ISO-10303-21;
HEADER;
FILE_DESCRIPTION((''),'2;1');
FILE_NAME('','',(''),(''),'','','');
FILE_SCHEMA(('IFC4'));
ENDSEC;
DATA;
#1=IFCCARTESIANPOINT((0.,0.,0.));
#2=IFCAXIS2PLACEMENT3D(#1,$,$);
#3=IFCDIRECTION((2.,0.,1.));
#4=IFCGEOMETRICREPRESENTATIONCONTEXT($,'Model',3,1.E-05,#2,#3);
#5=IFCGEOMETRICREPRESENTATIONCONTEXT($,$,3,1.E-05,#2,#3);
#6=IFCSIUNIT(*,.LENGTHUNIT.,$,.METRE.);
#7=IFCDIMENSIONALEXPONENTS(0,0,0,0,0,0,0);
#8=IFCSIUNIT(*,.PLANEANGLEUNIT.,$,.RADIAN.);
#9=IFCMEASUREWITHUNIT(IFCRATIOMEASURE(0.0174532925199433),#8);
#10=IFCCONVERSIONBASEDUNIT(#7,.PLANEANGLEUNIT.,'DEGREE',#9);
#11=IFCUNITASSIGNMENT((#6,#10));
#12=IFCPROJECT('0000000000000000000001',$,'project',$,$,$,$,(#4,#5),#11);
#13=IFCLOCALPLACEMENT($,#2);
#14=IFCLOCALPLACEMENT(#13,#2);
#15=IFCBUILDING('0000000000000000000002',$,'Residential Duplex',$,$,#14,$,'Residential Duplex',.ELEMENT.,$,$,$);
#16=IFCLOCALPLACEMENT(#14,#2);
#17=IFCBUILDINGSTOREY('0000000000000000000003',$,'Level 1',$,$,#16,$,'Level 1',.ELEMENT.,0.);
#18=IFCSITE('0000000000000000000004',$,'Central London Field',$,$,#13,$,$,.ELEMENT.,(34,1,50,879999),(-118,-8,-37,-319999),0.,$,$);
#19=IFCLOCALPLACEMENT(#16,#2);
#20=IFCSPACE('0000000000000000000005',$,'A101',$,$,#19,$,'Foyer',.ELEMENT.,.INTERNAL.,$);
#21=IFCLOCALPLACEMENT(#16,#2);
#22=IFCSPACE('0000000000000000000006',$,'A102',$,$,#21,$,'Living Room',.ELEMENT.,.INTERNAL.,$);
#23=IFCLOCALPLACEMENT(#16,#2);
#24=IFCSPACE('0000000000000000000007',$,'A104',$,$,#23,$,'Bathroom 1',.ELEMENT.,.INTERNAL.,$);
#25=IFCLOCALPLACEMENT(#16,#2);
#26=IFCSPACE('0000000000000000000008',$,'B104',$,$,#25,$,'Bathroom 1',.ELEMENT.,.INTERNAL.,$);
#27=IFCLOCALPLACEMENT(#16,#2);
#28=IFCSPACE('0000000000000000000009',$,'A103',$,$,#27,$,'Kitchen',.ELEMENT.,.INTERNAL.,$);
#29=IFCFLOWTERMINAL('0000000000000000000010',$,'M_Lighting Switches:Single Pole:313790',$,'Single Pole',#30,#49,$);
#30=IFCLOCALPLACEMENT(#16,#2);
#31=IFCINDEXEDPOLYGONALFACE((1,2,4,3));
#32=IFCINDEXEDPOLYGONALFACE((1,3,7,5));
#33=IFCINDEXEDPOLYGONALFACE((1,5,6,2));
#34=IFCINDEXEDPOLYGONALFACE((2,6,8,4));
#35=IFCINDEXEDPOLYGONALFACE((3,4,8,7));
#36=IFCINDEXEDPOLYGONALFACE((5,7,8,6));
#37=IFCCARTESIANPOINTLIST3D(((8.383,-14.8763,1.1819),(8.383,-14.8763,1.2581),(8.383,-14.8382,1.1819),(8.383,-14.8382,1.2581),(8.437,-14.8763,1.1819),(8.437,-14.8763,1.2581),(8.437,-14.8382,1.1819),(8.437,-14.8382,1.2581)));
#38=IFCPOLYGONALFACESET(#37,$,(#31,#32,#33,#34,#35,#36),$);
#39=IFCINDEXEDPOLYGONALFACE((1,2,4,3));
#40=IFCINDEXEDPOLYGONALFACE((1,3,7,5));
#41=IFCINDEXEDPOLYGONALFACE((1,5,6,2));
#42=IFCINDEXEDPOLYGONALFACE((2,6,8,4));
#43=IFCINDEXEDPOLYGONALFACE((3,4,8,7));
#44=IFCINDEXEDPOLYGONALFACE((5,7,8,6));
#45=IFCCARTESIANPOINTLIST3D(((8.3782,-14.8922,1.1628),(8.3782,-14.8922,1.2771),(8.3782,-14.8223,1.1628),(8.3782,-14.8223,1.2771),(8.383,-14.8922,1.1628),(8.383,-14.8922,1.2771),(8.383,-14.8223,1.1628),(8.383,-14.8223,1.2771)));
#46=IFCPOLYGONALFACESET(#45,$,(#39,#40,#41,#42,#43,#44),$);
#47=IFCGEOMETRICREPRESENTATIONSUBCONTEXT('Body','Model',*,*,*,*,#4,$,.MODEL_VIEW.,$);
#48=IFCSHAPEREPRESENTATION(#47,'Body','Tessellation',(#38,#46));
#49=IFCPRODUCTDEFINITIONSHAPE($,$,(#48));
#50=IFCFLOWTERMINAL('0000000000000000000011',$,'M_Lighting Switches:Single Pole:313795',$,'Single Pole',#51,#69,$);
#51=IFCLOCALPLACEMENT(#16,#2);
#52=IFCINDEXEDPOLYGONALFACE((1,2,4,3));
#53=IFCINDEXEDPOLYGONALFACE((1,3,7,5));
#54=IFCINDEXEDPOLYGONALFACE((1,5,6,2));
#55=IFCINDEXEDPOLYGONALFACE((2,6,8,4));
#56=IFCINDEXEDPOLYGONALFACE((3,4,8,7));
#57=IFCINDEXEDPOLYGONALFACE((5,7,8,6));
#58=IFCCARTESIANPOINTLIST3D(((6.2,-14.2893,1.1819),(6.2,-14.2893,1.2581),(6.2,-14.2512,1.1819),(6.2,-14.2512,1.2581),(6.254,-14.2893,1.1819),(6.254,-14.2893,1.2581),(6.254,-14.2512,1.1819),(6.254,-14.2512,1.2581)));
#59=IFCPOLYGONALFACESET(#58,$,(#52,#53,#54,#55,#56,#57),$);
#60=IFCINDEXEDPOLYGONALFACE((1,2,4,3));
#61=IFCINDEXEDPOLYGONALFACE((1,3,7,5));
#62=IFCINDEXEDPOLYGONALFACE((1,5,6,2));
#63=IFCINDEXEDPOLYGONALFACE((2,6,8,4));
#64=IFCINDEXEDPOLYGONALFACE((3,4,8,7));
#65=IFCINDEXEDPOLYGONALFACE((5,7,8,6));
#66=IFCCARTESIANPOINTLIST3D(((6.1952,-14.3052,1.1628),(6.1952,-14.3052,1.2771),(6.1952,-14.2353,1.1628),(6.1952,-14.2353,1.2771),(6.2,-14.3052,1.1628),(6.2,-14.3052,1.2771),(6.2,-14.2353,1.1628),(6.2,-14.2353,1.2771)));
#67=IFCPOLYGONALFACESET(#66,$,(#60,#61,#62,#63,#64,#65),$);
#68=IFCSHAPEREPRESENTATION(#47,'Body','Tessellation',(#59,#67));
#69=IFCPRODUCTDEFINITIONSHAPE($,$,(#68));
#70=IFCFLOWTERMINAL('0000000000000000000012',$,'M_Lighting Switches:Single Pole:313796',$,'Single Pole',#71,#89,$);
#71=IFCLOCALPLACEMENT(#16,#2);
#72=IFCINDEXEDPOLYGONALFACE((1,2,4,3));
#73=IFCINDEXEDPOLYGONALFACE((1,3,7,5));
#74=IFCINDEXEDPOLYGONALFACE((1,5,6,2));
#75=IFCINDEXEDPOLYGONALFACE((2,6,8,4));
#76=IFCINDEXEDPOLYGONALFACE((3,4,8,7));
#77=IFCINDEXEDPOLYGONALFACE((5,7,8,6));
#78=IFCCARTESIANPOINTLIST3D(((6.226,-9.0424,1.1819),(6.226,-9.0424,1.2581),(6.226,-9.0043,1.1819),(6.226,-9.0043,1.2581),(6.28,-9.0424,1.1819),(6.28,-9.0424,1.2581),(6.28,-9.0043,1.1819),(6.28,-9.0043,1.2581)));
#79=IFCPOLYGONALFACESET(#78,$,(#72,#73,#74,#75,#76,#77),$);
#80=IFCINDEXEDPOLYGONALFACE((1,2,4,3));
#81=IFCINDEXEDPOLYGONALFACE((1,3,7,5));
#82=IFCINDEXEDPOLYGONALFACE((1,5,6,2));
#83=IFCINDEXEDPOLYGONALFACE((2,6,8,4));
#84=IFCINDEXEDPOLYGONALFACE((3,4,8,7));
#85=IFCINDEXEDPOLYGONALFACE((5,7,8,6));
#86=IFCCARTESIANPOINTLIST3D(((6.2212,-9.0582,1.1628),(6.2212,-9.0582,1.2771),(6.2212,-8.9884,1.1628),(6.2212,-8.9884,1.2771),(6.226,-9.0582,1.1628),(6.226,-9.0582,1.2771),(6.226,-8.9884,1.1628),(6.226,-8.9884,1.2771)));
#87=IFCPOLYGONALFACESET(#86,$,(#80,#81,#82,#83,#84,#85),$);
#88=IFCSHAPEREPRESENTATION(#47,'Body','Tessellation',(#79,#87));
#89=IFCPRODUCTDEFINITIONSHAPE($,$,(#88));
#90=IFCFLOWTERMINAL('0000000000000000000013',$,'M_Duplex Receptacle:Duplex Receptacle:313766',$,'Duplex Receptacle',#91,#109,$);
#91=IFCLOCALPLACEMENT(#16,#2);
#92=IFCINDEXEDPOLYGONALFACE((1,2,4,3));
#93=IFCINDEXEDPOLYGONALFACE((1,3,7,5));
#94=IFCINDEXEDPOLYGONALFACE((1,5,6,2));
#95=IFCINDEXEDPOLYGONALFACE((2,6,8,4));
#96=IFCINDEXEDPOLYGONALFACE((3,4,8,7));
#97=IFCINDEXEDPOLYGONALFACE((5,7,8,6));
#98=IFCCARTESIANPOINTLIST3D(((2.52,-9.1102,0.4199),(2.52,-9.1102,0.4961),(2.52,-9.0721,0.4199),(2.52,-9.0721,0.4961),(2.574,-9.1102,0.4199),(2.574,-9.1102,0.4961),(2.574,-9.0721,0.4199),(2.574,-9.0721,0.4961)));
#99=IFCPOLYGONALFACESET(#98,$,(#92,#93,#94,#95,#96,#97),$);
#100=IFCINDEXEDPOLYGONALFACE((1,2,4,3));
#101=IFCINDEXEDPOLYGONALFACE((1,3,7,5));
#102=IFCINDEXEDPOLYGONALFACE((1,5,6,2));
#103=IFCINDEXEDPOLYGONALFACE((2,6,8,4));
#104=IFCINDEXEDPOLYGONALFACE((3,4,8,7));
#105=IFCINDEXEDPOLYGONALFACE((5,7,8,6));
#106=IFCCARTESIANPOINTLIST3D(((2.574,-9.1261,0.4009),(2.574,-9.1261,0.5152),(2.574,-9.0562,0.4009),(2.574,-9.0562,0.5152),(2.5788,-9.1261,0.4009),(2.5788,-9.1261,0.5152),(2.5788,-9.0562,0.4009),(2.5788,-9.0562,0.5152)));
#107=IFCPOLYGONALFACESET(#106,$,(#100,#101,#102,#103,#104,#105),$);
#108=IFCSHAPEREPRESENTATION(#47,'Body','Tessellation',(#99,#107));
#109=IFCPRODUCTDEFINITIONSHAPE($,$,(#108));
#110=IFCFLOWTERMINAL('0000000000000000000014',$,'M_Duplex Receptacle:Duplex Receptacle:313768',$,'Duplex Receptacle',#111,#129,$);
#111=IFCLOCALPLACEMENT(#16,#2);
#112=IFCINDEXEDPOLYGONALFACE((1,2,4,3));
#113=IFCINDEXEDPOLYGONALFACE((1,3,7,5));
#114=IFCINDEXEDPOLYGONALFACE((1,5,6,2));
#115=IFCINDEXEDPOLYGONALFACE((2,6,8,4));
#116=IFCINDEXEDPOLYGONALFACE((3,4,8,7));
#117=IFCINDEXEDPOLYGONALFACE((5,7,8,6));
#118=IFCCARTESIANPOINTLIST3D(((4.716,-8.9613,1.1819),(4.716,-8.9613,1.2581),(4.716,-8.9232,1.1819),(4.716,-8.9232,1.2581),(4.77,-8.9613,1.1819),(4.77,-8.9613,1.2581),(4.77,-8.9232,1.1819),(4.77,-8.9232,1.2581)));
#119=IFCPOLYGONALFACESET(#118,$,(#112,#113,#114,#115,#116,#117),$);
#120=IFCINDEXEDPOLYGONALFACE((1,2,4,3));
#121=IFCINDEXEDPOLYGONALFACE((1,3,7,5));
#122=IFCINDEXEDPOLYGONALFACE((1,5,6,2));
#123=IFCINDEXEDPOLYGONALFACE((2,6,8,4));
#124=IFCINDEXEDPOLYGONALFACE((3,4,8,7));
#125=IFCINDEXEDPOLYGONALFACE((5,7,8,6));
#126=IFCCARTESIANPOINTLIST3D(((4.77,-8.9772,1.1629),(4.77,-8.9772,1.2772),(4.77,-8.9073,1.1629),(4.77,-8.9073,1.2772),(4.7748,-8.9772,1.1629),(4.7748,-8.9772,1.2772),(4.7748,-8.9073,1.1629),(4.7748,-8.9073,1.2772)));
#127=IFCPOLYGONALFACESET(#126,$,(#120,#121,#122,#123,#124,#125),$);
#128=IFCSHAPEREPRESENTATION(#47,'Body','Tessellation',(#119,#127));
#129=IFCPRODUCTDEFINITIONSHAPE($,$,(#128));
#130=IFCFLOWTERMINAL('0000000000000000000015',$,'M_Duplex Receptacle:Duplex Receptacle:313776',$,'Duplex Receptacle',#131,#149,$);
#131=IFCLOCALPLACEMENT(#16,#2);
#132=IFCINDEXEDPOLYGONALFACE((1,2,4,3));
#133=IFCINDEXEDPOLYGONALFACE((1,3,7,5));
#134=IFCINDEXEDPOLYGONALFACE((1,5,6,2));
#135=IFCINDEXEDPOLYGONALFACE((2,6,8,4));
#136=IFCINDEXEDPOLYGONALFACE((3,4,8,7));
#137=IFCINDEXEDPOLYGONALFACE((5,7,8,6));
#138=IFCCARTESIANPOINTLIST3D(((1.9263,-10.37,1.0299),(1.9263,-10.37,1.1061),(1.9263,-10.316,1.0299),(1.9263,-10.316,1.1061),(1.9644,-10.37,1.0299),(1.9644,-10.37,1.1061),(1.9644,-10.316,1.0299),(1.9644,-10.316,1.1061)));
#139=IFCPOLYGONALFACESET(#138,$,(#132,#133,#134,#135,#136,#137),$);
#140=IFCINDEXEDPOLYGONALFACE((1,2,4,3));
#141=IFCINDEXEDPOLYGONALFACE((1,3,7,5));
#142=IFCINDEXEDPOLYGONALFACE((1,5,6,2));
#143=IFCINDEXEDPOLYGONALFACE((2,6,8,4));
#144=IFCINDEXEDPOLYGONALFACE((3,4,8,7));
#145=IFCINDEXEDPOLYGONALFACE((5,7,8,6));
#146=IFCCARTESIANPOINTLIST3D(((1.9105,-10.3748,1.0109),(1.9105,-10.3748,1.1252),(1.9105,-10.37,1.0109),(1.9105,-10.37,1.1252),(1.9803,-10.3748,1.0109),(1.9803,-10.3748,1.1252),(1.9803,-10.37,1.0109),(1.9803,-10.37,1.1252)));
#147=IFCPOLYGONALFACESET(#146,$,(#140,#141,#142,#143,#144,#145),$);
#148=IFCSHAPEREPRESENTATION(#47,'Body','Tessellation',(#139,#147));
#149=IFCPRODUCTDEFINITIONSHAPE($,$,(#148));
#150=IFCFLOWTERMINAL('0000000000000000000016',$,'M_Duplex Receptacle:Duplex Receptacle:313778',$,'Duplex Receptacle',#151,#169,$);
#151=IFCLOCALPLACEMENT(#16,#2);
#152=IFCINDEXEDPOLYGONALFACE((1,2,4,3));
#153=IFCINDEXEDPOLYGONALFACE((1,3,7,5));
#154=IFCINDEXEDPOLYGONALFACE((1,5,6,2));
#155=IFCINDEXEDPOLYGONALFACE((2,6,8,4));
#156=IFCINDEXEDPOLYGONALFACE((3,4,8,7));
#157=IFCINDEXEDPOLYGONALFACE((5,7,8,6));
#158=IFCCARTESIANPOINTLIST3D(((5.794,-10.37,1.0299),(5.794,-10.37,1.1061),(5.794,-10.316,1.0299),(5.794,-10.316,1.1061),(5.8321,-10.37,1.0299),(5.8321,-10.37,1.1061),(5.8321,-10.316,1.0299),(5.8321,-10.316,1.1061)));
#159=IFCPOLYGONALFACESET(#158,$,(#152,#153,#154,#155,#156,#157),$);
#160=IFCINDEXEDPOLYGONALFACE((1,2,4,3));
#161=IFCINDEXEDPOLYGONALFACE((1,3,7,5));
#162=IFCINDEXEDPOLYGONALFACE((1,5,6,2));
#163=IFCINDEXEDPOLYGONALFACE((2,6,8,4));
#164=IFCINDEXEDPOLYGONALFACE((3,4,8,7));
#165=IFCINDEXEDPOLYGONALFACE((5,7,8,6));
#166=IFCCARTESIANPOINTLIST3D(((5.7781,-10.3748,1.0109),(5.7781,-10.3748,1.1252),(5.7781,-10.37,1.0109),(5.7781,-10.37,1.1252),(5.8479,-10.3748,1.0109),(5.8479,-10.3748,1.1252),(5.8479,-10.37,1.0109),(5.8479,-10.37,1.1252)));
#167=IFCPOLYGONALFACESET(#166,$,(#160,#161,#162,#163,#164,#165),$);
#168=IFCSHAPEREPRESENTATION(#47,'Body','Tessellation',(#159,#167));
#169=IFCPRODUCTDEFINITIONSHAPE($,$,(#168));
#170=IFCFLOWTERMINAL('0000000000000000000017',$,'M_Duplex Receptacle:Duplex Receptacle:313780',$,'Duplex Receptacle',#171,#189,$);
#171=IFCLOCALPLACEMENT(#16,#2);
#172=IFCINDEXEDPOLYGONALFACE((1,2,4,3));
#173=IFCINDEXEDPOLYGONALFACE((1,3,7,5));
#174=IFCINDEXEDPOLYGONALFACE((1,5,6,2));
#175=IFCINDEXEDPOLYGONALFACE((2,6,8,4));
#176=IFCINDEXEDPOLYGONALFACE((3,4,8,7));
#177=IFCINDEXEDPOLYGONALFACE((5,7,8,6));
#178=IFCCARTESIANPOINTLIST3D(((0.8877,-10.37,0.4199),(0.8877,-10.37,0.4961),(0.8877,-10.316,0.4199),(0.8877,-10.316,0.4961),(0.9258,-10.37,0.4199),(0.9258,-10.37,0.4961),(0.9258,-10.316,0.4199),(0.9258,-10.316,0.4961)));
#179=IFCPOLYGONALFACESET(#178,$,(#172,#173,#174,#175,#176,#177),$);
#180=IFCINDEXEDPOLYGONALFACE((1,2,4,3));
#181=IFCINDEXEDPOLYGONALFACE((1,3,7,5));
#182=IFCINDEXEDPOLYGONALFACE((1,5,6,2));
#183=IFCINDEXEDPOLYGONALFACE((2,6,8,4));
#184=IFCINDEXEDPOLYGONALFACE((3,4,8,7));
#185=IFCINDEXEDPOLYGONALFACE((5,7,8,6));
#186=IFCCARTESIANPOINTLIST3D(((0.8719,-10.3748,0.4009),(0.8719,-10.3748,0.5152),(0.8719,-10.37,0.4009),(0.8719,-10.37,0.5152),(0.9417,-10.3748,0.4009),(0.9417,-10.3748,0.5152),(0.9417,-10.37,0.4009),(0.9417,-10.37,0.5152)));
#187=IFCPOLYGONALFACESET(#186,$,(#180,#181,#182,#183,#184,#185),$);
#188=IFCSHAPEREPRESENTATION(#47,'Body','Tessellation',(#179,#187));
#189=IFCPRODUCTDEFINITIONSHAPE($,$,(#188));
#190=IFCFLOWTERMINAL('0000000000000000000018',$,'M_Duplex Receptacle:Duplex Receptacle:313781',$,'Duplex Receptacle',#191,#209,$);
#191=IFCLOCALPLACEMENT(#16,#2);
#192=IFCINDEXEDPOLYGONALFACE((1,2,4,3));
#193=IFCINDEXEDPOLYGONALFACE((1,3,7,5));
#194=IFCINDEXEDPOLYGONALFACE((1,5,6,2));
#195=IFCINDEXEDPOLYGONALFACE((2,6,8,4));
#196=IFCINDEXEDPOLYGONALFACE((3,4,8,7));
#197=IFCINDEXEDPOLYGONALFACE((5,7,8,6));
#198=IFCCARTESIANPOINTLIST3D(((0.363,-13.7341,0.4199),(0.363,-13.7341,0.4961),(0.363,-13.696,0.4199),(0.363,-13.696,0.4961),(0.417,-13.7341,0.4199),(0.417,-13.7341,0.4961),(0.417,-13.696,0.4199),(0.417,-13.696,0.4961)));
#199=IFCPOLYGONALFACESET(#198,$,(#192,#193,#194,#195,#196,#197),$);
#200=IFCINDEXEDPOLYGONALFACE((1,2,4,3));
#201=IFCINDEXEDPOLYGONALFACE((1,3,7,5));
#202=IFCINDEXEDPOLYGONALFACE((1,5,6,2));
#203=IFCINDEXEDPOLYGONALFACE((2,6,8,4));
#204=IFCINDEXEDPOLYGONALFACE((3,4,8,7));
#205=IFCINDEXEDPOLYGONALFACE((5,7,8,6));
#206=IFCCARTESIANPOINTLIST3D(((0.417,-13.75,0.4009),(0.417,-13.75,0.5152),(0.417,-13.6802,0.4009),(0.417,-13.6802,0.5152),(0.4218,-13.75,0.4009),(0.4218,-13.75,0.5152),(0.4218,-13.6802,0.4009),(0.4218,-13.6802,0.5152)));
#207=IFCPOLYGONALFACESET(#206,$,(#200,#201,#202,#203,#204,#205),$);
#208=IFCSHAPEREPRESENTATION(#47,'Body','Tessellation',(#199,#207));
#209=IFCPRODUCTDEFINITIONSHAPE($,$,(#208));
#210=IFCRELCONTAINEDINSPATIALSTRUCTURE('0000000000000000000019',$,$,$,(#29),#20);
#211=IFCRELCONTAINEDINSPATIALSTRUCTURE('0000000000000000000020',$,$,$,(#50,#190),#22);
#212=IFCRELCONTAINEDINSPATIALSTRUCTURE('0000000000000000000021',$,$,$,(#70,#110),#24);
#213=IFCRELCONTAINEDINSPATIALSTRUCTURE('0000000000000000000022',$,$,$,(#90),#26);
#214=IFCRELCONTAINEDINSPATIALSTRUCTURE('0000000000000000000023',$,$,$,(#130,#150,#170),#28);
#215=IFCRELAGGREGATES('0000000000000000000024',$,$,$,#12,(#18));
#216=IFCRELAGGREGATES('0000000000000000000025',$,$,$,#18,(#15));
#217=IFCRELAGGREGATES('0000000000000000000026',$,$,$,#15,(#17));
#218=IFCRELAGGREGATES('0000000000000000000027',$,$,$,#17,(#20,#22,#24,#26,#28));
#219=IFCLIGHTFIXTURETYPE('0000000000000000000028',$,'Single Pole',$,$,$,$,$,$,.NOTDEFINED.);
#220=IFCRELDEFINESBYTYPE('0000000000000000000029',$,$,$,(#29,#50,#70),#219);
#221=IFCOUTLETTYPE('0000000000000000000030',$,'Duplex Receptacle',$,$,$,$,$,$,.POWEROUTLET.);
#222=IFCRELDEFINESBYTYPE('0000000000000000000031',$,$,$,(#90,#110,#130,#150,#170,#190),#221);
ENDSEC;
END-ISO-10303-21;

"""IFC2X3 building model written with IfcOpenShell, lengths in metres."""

from ifc_helpers import new_model, entity, si_unit, converted_unit, direction, frame, frame_2d, origin, origin_2d_with_axis, place, context, subcontext, project, spatial, rectangle, extrude, source, transform, mapped, type_object, type_shapes, element, save


model = new_model("IFC2X3")

# Units and contexts
model_context = context("Model", 3, precision=1e-05, world=origin(), true_north=direction((2.0, 0.0, 1.0)))
context_of_model = context(None, 3, precision=1e-05, world=origin(), true_north=direction((2.0, 0.0, 1.0)))
body_context = subcontext(model_context, "Body", "Model", "MODEL_VIEW")
ifc_project = project(units=[si_unit("LENGTHUNIT", "METRE"), converted_unit("PLANEANGLEUNIT", "DEGREE", entity("IfcRatioMeasure", 0.0174532925199433), si_unit("PLANEANGLEUNIT", "RADIAN"), dimensions=[0, 0, 0, 0, 0, 0, 0])], contexts=[model_context, context_of_model])

# Site, building, storey, space
site_placement = place(None, origin())
site = spatial("IfcSite", under=ifc_project, at=site_placement, Name="Central London Field", CompositionType="ELEMENT", RefLatitude=(34, 1, 50, 879999), RefLongitude=(-118, -8, -37, -319999), RefElevation=0.0)
building_placement = place(site_placement, origin())
building = spatial("IfcBuilding", under=site, at=building_placement, Name="Residential Duplex", LongName="Residential Duplex", CompositionType="ELEMENT")
storey_placement = place(building_placement, origin())
storey = spatial("IfcBuildingStorey", under=building, at=storey_placement, Name="Level 1", LongName="Level 1", CompositionType="ELEMENT", Elevation=0.0)
space_1_placement = place(storey_placement, origin())
space_1 = spatial("IfcSpace", under=storey, at=space_1_placement, Name="A101", LongName="Foyer", CompositionType="ELEMENT", InteriorOrExteriorSpace="INTERNAL")

# Flow terminal
light_fixture_type = type_object("IfcLightFixtureType", Name="Single Pole", PredefinedType="NOTDEFINED")
shared_shape_1 = source(origin(), body_context, "Body", "SweptSolid", [
    extrude(rectangle(XDim=0.0381, YDim=0.0762, at=origin_2d_with_axis()), frame((0.0, 0.0, -0.054), z_axis=(0.0, 0.0, 1.0), x_axis=(-1.0, 0.0, 0.0)), (0.0, 0.0, 1.0), 0.054),
    extrude(rectangle(XDim=0.0698, YDim=0.1143, at=frame_2d((0.0, 0.0), x_axis=(1.0, 0.0))), frame((0.0, 0.0, 0.0), z_axis=(0.0, 0.0, 1.0), x_axis=(-1.0, 0.0, 0.0)), (0.0, 0.0, 1.0), 0.0048),
])
type_shapes(light_fixture_type, [shared_shape_1])
flow_terminal_1_placement = place(space_1_placement, frame((8.383, -14.8573, 1.22), z_axis=(-1.0, 0.0, 0.0), x_axis=(0.0, -1.0, 0.0)))
element("IfcFlowTerminal", 1, at=flow_terminal_1_placement, inside=space_1, type_object=light_fixture_type, Name="M_Lighting Switches:Single Pole:313790", ObjectType="Single Pole", context=body_context, shape_type="MappedRepresentation", body=[
    mapped(shared_shape_1, transform((0.0, 0.0, 0.0), scale=1.0)),
])

# Shared definitions
space_2_placement = place(storey_placement, origin())
space_2 = spatial("IfcSpace", under=storey, at=space_2_placement, Name="A102", LongName="Living Room", CompositionType="ELEMENT", InteriorOrExteriorSpace="INTERNAL")

# Flow terminal
flow_terminal_2_placement = place(space_2_placement, frame((6.2, -14.2702, 1.22), z_axis=(-1.0, 0.0, 0.0), x_axis=(0.0, -1.0, 0.0)))
element("IfcFlowTerminal", 2, at=flow_terminal_2_placement, inside=space_2, type_object=light_fixture_type, Name="M_Lighting Switches:Single Pole:313795", ObjectType="Single Pole", context=body_context, shape_type="MappedRepresentation", body=[
    mapped(shared_shape_1, transform((0.0, 0.0, 0.0), scale=1.0)),
])

# Shared definitions
space_3_placement = place(storey_placement, origin())
space_3 = spatial("IfcSpace", under=storey, at=space_3_placement, Name="A104", LongName="Bathroom 1", CompositionType="ELEMENT", InteriorOrExteriorSpace="INTERNAL")

# Flow terminal
flow_terminal_3_placement = place(space_3_placement, frame((6.226, -9.0233, 1.22), z_axis=(-1.0, 0.0, 0.0), x_axis=(0.0, -1.0, 0.0)))
element("IfcFlowTerminal", 3, at=flow_terminal_3_placement, inside=space_3, type_object=light_fixture_type, Name="M_Lighting Switches:Single Pole:313796", ObjectType="Single Pole", context=body_context, shape_type="MappedRepresentation", body=[
    mapped(shared_shape_1, transform((0.0, 0.0, 0.0), scale=1.0)),
])

# Shared definitions
space_4_placement = place(storey_placement, origin())
space_4 = spatial("IfcSpace", under=storey, at=space_4_placement, Name="B104", LongName="Bathroom 1", CompositionType="ELEMENT", InteriorOrExteriorSpace="INTERNAL")

# Flow terminals
outlet_type = type_object("IfcOutletType", Name="Duplex Receptacle", PredefinedType="POWEROUTLET")
shared_shape_2 = source(origin(), body_context, "Body", "SweptSolid", [
    extrude(rectangle(XDim=0.0381, YDim=0.0762, at=origin_2d_with_axis()), frame((0.0, 0.0, -0.054), z_axis=(0.0, 0.0, 1.0), x_axis=(-1.0, 0.0, 0.0)), (0.0, 0.0, 1.0), 0.054),
    extrude(rectangle(XDim=0.0698, YDim=0.1143, at=frame_2d((0.0, 0.0), x_axis=(1.0, 0.0))), frame((0.0, 0.0, 0.0), z_axis=(0.0, 0.0, 1.0), x_axis=(-1.0, 0.0, 0.0)), (0.0, 0.0, 1.0), 0.0048),
])
type_shapes(outlet_type, [shared_shape_2])
flow_terminal_4_placement = place(space_4_placement, frame((2.574, -9.0912, 0.458), z_axis=(1.0, 0.0, 0.0), x_axis=(0.0, 1.0, 0.0)))
element("IfcFlowTerminal", 4, at=flow_terminal_4_placement, inside=space_4, type_object=outlet_type, Name="M_Duplex Receptacle:Duplex Receptacle:313766", ObjectType="Duplex Receptacle", context=body_context, shape_type="MappedRepresentation", body=[
    mapped(shared_shape_2, transform((0.0, 0.0, 0.0), scale=1.0)),
])
flow_terminal_5_placement = place(space_3_placement, frame((4.77, -8.9422, 1.22), z_axis=(1.0, 0.0, 0.0), x_axis=(0.0, 1.0, 0.0)))
element("IfcFlowTerminal", 5, at=flow_terminal_5_placement, inside=space_3, type_object=outlet_type, Name="M_Duplex Receptacle:Duplex Receptacle:313768", ObjectType="Duplex Receptacle", context=body_context, shape_type="MappedRepresentation", body=[
    mapped(shared_shape_2, transform((0.0, 0.0, 0.0), scale=1.0)),
])

# Shared definitions
space_5_placement = place(storey_placement, origin())
space_5 = spatial("IfcSpace", under=storey, at=space_5_placement, Name="A103", LongName="Kitchen", CompositionType="ELEMENT", InteriorOrExteriorSpace="INTERNAL")

# Flow terminals
for number, where, z_axis, x_axis, name in (
    (6, (1.9454, -10.37, 1.068), (0.0, -1.0, 0.0), (1.0, 0.0, 0.0), "M_Duplex Receptacle:Duplex Receptacle:313776"),
    (7, (5.813, -10.37, 1.068), (0.0, -1.0, 0.0), (1.0, 0.0, 0.0), "M_Duplex Receptacle:Duplex Receptacle:313778"),
    (8, (0.9068, -10.37, 0.458), (0.0, -1.0, 0.0), (1.0, 0.0, 0.0), "M_Duplex Receptacle:Duplex Receptacle:313780"),
):
    element("IfcFlowTerminal", number, at=place(space_5_placement, frame(where, z_axis=z_axis, x_axis=x_axis)), inside=space_5, type_object=outlet_type, Name=name, ObjectType="Duplex Receptacle", context=body_context, shape_type="MappedRepresentation", body=[
        mapped(shared_shape_2, transform((0.0, 0.0, 0.0), scale=1.0)),
    ])
for number, where, z_axis, x_axis, name in (
    (9, (0.417, -13.7151, 0.458), (1.0, 0.0, 0.0), (0.0, 1.0, 0.0), "M_Duplex Receptacle:Duplex Receptacle:313781"),
):
    element("IfcFlowTerminal", number, at=place(space_2_placement, frame(where, z_axis=z_axis, x_axis=x_axis)), inside=space_2, type_object=outlet_type, Name=name, ObjectType="Duplex Receptacle", context=body_context, shape_type="MappedRepresentation", body=[
        mapped(shared_shape_2, transform((0.0, 0.0, 0.0), scale=1.0)),
    ])

save(model, "model.ifc")
